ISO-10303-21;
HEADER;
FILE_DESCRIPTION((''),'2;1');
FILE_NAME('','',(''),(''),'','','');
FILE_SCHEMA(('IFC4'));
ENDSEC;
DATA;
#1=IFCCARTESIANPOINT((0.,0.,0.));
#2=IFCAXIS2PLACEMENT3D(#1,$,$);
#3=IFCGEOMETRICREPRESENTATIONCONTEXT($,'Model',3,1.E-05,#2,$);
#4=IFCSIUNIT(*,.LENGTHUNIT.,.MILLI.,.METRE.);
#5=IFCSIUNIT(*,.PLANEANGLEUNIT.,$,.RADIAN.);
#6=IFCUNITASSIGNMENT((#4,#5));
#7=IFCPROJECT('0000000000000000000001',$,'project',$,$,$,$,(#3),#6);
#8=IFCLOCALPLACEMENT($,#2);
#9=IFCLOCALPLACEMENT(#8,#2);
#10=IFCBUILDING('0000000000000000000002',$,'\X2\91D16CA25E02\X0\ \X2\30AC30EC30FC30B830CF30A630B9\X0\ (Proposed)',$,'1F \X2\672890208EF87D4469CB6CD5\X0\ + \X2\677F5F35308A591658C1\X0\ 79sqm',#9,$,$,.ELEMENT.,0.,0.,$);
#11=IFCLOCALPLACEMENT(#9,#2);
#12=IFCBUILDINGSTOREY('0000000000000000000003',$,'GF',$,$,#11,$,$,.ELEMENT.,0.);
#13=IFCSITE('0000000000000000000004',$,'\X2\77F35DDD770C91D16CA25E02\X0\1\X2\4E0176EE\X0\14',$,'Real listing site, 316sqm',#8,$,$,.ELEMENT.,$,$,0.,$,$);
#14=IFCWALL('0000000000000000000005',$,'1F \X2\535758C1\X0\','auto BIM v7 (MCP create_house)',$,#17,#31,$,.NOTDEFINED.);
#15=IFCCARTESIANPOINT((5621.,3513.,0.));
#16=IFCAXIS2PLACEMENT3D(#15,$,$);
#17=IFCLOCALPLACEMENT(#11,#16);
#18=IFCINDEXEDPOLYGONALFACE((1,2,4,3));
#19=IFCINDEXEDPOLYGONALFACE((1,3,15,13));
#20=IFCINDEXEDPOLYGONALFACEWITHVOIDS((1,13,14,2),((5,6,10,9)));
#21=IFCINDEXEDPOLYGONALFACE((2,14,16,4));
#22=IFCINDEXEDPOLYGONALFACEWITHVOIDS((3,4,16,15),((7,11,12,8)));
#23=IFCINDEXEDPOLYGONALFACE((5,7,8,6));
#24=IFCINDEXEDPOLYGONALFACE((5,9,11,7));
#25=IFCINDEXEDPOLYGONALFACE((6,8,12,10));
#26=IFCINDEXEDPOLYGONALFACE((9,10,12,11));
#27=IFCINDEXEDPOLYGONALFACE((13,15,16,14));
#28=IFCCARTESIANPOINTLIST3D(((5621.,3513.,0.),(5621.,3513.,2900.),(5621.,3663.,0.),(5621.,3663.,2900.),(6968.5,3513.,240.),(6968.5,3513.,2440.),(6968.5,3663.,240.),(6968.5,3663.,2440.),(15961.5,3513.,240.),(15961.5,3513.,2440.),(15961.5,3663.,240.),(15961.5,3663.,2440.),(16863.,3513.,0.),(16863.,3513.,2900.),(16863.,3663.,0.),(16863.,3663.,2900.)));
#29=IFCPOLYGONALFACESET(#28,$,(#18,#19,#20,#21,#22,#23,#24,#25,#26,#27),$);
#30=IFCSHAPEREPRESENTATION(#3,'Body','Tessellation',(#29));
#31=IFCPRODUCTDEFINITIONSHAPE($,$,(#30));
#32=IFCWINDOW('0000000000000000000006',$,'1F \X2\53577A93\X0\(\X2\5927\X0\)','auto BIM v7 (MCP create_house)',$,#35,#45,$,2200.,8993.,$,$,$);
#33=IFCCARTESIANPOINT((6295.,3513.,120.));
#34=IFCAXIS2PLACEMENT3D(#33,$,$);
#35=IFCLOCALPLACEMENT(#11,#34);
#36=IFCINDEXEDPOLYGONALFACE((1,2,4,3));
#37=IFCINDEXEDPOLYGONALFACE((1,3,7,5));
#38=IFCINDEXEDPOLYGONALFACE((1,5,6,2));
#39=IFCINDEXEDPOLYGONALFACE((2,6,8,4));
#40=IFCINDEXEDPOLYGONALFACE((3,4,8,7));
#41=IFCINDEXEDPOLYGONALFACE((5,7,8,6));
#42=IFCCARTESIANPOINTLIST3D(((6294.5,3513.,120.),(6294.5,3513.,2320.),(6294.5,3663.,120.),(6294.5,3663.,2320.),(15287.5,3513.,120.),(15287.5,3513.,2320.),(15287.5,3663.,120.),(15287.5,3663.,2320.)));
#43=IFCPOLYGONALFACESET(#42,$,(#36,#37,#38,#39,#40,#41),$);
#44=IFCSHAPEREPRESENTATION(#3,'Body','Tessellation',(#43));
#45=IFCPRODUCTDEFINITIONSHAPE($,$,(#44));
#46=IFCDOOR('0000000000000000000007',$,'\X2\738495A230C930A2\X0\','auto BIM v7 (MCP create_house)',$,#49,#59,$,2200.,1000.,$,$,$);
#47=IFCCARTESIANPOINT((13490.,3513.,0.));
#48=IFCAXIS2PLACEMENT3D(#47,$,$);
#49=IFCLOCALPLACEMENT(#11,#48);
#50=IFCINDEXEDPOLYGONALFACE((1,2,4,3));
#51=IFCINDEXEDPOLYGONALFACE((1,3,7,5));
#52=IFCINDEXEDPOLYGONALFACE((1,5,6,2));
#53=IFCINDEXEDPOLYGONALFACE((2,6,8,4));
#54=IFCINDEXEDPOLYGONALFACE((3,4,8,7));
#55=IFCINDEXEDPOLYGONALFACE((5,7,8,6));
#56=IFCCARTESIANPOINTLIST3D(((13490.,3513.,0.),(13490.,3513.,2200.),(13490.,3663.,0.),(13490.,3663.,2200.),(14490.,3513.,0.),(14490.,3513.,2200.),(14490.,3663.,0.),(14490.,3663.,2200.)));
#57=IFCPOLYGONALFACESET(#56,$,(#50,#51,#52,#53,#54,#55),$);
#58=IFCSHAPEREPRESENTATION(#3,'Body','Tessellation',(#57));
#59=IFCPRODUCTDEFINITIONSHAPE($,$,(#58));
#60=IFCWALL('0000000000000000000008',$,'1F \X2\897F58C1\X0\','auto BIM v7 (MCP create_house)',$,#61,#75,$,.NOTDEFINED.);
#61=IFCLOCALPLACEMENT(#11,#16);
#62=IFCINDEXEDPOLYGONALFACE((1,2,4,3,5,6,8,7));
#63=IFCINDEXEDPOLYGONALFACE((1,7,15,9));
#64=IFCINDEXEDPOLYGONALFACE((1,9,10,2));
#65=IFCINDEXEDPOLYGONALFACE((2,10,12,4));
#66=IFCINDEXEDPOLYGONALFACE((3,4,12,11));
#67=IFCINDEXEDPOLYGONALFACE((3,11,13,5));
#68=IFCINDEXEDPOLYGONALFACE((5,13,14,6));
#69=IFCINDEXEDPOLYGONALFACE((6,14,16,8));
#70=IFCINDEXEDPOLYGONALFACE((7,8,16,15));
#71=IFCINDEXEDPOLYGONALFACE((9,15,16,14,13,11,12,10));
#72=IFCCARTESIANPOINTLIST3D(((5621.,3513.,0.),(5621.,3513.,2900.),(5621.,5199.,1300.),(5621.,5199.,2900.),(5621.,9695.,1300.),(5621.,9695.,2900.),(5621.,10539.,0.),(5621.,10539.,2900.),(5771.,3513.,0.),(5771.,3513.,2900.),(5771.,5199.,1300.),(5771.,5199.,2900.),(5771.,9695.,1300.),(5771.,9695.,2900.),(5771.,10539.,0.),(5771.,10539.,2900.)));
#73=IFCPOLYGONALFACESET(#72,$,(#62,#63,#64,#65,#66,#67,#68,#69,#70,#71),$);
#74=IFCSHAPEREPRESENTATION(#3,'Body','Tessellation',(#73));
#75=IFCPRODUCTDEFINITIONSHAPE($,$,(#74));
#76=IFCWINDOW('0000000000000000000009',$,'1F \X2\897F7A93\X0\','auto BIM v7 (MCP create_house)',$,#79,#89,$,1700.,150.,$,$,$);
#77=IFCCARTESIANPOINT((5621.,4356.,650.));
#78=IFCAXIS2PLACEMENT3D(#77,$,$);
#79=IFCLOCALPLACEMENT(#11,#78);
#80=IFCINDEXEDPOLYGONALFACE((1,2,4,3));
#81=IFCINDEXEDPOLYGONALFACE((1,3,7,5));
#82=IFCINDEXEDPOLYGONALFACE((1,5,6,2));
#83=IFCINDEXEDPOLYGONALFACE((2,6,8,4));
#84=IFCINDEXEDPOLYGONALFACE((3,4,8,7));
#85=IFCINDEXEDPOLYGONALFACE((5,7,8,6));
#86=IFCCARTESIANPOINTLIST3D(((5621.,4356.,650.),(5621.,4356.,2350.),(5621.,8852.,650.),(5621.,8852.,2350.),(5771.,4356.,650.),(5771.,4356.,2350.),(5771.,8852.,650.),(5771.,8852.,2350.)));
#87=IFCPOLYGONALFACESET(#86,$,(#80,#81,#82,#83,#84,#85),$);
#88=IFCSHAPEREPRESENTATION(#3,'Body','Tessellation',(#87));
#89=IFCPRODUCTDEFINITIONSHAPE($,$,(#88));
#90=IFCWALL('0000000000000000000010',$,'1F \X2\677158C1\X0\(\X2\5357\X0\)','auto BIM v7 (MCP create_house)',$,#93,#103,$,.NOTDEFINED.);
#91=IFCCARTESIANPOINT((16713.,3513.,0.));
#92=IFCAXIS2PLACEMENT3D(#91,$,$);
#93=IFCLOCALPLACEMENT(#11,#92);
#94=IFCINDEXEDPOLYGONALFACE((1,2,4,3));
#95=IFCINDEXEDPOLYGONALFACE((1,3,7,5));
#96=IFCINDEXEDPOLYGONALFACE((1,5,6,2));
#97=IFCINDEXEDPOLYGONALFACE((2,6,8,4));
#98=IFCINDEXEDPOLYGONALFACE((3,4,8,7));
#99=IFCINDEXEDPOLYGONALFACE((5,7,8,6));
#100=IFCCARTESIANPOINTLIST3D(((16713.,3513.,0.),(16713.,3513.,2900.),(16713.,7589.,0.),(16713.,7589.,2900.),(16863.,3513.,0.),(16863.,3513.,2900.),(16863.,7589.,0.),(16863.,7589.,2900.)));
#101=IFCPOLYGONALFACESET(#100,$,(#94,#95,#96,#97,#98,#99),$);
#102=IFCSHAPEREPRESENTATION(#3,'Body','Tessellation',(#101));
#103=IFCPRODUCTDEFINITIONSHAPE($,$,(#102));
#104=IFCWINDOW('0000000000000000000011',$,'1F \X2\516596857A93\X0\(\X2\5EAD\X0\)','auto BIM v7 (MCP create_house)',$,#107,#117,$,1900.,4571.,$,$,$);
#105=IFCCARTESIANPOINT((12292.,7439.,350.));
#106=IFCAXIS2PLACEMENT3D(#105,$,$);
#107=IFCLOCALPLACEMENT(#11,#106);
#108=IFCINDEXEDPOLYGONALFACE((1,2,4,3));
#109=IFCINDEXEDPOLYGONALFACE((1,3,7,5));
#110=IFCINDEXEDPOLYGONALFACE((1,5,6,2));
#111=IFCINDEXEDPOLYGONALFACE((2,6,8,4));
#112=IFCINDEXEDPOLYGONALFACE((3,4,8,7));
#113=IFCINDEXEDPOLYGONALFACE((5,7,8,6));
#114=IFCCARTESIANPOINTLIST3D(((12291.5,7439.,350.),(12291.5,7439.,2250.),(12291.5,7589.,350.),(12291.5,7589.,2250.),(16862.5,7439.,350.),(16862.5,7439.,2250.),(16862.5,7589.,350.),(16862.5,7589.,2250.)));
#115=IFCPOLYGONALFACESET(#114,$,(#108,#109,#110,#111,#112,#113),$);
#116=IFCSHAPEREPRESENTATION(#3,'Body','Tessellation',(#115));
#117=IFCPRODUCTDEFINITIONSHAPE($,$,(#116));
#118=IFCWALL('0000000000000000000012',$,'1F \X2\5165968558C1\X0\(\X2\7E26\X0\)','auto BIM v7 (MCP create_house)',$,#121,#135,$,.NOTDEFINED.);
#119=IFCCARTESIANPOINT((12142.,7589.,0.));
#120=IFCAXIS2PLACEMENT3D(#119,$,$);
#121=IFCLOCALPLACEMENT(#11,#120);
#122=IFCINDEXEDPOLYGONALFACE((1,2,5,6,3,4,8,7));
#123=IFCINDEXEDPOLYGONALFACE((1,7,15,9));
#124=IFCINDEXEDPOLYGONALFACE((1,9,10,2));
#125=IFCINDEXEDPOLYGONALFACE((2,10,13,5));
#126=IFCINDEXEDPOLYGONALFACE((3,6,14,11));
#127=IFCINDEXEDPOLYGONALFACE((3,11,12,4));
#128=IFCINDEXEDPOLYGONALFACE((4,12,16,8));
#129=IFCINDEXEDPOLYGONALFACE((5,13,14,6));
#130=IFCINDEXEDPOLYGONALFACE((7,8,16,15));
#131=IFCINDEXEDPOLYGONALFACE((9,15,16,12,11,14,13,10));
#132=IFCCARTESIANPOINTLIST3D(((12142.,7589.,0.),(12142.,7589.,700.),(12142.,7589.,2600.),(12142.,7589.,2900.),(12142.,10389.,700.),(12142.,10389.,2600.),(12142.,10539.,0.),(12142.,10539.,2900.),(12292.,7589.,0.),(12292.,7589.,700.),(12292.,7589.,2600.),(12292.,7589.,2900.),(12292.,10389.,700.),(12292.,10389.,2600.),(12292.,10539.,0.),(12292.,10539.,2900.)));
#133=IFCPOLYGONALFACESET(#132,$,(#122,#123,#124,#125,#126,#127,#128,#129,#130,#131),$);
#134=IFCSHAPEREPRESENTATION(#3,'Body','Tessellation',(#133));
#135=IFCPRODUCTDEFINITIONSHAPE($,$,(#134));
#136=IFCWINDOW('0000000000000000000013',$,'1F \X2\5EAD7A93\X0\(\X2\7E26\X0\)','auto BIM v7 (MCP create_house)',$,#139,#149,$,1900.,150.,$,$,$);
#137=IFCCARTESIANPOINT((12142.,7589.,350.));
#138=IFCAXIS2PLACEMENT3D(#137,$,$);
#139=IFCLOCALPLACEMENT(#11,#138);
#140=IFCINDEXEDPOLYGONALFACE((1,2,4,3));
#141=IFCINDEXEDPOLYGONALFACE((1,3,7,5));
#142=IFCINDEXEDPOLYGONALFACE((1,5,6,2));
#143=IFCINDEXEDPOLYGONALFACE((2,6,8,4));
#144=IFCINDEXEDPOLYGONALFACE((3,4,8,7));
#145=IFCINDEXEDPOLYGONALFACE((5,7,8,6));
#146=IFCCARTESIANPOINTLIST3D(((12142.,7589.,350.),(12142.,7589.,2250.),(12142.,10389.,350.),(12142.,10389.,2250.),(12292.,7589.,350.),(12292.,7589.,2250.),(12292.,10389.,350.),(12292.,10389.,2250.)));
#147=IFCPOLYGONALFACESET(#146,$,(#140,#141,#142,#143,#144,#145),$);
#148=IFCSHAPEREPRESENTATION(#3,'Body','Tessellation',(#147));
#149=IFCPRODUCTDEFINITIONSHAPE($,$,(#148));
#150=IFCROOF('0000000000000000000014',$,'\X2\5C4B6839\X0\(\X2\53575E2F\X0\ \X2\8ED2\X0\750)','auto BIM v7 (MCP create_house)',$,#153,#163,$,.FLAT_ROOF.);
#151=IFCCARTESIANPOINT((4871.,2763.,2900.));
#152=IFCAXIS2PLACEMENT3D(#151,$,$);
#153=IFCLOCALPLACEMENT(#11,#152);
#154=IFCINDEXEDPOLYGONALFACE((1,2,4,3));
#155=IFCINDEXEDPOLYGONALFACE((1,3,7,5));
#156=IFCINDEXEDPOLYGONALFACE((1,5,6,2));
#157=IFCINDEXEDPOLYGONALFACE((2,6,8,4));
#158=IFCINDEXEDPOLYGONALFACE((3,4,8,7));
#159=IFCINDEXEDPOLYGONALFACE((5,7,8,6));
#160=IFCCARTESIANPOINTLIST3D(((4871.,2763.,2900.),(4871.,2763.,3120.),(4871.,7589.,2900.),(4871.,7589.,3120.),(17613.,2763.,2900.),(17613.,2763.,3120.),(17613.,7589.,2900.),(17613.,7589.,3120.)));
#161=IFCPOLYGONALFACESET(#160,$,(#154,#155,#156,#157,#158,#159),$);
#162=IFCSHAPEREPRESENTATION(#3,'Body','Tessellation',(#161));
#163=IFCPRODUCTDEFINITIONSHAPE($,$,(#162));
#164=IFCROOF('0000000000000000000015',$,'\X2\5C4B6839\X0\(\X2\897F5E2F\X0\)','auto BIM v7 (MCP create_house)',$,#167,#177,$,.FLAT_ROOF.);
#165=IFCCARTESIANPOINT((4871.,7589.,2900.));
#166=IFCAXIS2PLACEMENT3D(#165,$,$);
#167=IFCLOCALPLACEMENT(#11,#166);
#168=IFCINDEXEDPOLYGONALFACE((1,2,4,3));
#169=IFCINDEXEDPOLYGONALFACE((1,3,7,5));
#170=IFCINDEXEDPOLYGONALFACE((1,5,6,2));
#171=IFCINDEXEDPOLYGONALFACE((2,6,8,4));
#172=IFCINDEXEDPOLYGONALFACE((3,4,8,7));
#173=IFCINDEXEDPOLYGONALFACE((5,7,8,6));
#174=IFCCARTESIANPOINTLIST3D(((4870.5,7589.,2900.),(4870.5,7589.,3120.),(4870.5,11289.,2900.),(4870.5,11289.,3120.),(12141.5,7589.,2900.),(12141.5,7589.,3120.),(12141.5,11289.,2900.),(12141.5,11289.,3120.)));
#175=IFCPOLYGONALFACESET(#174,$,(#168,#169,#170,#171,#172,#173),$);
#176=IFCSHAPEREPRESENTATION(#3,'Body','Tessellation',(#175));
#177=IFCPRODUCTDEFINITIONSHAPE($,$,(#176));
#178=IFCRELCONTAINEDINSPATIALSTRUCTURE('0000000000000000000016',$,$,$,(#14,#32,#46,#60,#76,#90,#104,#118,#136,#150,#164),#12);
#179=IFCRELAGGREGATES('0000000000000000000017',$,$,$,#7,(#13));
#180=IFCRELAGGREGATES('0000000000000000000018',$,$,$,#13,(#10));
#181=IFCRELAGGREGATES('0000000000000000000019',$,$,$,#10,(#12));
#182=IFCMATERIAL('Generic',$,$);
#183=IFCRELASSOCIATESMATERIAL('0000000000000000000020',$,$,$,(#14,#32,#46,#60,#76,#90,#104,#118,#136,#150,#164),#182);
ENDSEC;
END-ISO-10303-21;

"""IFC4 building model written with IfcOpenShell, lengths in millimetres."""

from ifc_helpers import new_model, si_unit, frame, frame_2d, origin, place, context, project, spatial, rectangle, extrude, material, element, fill, save


model = new_model("IFC4")

# Units and contexts
model_context = context("Model", 3, precision=1e-05, world=origin())
ifc_project = project(units=[si_unit("LENGTHUNIT", "METRE", prefix="MILLI"), si_unit("PLANEANGLEUNIT", "RADIAN")], contexts=[model_context])

# Site, building, storey
site_placement = place(None, origin())
site = spatial("IfcSite", under=ifc_project, at=site_placement, Name="石川県金沢市1丁目14", ObjectType="Real listing site, 316sqm", CompositionType="ELEMENT", RefElevation=0.0)
building_placement = place(site_placement, origin())
building = spatial("IfcBuilding", under=site, at=building_placement, Name="金沢市 ガレージハウス (Proposed)", ObjectType="1F 木造軸組構法 + 板張り外壁 79sqm", CompositionType="ELEMENT", ElevationOfRefHeight=0.0, ElevationOfTerrain=0.0)
storey_placement = place(building_placement, origin())
storey = spatial("IfcBuildingStorey", under=building, at=storey_placement, Name="GF", CompositionType="ELEMENT", Elevation=0.0)

# Shared definitions
ifc_material = material(Name="Generic")

# Wall, openings, window, door
wall_1_placement = place(storey_placement, frame((5621.0, 3513.0, 0.0)))
wall_1 = element("IfcWall", 1, at=wall_1_placement, inside=storey, material=ifc_material, Name="1F 南壁", Description="auto BIM v7 (MCP create_house)", PredefinedType="NOTDEFINED", context=model_context, shape_type="SweptSolid", body=[
    extrude(rectangle(XDim=11242.0, YDim=150.0, at=frame_2d((5621.0, 75.0))), frame((5621.0, 3513.0, 0.0)), (0.0, 0.0, 1.0), 2900.0),
])
opening_1_placement = place(storey_placement, frame((6295.0, 3513.0, 120.0)))
opening_1 = element("IfcOpeningElement", 2, at=opening_1_placement, cuts=wall_1, PredefinedType="NOTDEFINED", context=model_context, shape_type="SweptSolid", body=[
    extrude(rectangle(XDim=8993.0, YDim=150.0, at=frame_2d((4496.0, 75.0))), frame((6295.0, 3513.0, 120.0)), (0.0, 0.0, 1.0), 2200.0),
])
opening_2_placement = place(storey_placement, frame((13490.0, 3513.0, 0.0)))
opening_2 = element("IfcOpeningElement", 3, at=opening_2_placement, cuts=wall_1, PredefinedType="NOTDEFINED", context=model_context, shape_type="SweptSolid", body=[
    extrude(rectangle(XDim=1000.0, YDim=150.0, at=frame_2d((500.0, 75.0))), frame((13490.0, 3513.0, 0.0)), (0.0, 0.0, 1.0), 2200.0),
])
window_1_placement = place(storey_placement, frame((6295.0, 3513.0, 120.0)))
window_1 = element("IfcWindow", 4, at=window_1_placement, inside=storey, material=ifc_material, Name="1F 南窓(大)", Description="auto BIM v7 (MCP create_house)", OverallHeight=2200.0, OverallWidth=8993.0, context=model_context, shape_type="SweptSolid", body=[
    extrude(rectangle(XDim=8993.0, YDim=150.0, at=frame_2d((4496.0, 75.0))), frame((6295.0, 3513.0, 120.0)), (0.0, 0.0, 1.0), 2200.0),
])
fill(opening_1, window_1)
door_placement = place(storey_placement, frame((13490.0, 3513.0, 0.0)))
door = element("IfcDoor", 5, at=door_placement, inside=storey, material=ifc_material, Name="玄関ドア", Description="auto BIM v7 (MCP create_house)", OverallHeight=2200.0, OverallWidth=1000.0, context=model_context, shape_type="SweptSolid", body=[
    extrude(rectangle(XDim=1000.0, YDim=150.0, at=frame_2d((500.0, 75.0))), frame((13490.0, 3513.0, 0.0)), (0.0, 0.0, 1.0), 2200.0),
])
fill(opening_2, door)

# Wall, opening, window
wall_2_placement = place(storey_placement, frame((5621.0, 3513.0, 0.0)))
wall_2 = element("IfcWall", 6, at=wall_2_placement, inside=storey, material=ifc_material, Name="1F 西壁", Description="auto BIM v7 (MCP create_house)", PredefinedType="NOTDEFINED", context=model_context, shape_type="SweptSolid", body=[
    extrude(rectangle(XDim=150.0, YDim=7026.0, at=frame_2d((75.0, 3513.0))), frame((5621.0, 3513.0, 0.0)), (0.0, 0.0, 1.0), 2900.0),
])
opening_3_placement = place(storey_placement, frame((5621.0, 4356.0, 650.0)))
opening_3 = element("IfcOpeningElement", 7, at=opening_3_placement, cuts=wall_2, PredefinedType="NOTDEFINED", context=model_context, shape_type="SweptSolid", body=[
    extrude(rectangle(XDim=150.0, YDim=4496.0, at=frame_2d((75.0, 2248.0))), frame((5621.0, 4356.0, 650.0)), (0.0, 0.0, 1.0), 1700.0),
])
window_2_placement = place(storey_placement, frame((5621.0, 4356.0, 650.0)))
window_2 = element("IfcWindow", 8, at=window_2_placement, inside=storey, material=ifc_material, Name="1F 西窓", Description="auto BIM v7 (MCP create_house)", OverallHeight=1700.0, OverallWidth=150.0, context=model_context, shape_type="SweptSolid", body=[
    extrude(rectangle(XDim=150.0, YDim=4496.0, at=frame_2d((75.0, 2248.0))), frame((5621.0, 4356.0, 650.0)), (0.0, 0.0, 1.0), 1700.0),
])
fill(opening_3, window_2)

# Wall, opening, window
wall_3_placement = place(storey_placement, frame((16713.0, 3513.0, 0.0)))
wall_3 = element("IfcWall", 9, at=wall_3_placement, inside=storey, material=ifc_material, Name="1F 東壁(南)", Description="auto BIM v7 (MCP create_house)", PredefinedType="NOTDEFINED", context=model_context, shape_type="SweptSolid", body=[
    extrude(rectangle(XDim=150.0, YDim=4076.0, at=frame_2d((75.0, 2038.0))), frame((16713.0, 3513.0, 0.0)), (0.0, 0.0, 1.0), 2900.0),
])
opening_4_placement = place(storey_placement, frame((12292.0, 7439.0, 350.0)))
opening_4 = element("IfcOpeningElement", 10, at=opening_4_placement, cuts=wall_3, PredefinedType="NOTDEFINED", context=model_context, shape_type="SweptSolid", body=[
    extrude(rectangle(XDim=4571.0, YDim=150.0, at=frame_2d((2285.0, 75.0))), frame((12292.0, 7439.0, 350.0)), (0.0, 0.0, 1.0), 1900.0),
])
window_3_placement = place(storey_placement, frame((12292.0, 7439.0, 350.0)))
window_3 = element("IfcWindow", 11, at=window_3_placement, inside=storey, material=ifc_material, Name="1F 入隅窓(庭)", Description="auto BIM v7 (MCP create_house)", OverallHeight=1900.0, OverallWidth=4571.0, context=model_context, shape_type="SweptSolid", body=[
    extrude(rectangle(XDim=4571.0, YDim=150.0, at=frame_2d((2285.0, 75.0))), frame((12292.0, 7439.0, 350.0)), (0.0, 0.0, 1.0), 1900.0),
])
fill(opening_4, window_3)

# Wall, opening, window
wall_4_placement = place(storey_placement, frame((12142.0, 7589.0, 0.0)))
wall_4 = element("IfcWall", 12, at=wall_4_placement, inside=storey, material=ifc_material, Name="1F 入隅壁(縦)", Description="auto BIM v7 (MCP create_house)", PredefinedType="NOTDEFINED", context=model_context, shape_type="SweptSolid", body=[
    extrude(rectangle(XDim=150.0, YDim=2950.0, at=frame_2d((75.0, 1475.0))), frame((12142.0, 7589.0, 0.0)), (0.0, 0.0, 1.0), 2900.0),
])
opening_5_placement = place(storey_placement, frame((12142.0, 7589.0, 350.0)))
opening_5 = element("IfcOpeningElement", 13, at=opening_5_placement, cuts=wall_4, PredefinedType="NOTDEFINED", context=model_context, shape_type="SweptSolid", body=[
    extrude(rectangle(XDim=150.0, YDim=2800.0, at=frame_2d((75.0, 1400.0))), frame((12142.0, 7589.0, 350.0)), (0.0, 0.0, 1.0), 1900.0),
])
window_4_placement = place(storey_placement, frame((12142.0, 7589.0, 350.0)))
window_4 = element("IfcWindow", 14, at=window_4_placement, inside=storey, material=ifc_material, Name="1F 庭窓(縦)", Description="auto BIM v7 (MCP create_house)", OverallHeight=1900.0, OverallWidth=150.0, context=model_context, shape_type="SweptSolid", body=[
    extrude(rectangle(XDim=150.0, YDim=2800.0, at=frame_2d((75.0, 1400.0))), frame((12142.0, 7589.0, 350.0)), (0.0, 0.0, 1.0), 1900.0),
])
fill(opening_5, window_4)

# Roofs
roof_1_placement = place(storey_placement, frame((4871.0, 2763.0, 2900.0)))
element("IfcRoof", 15, at=roof_1_placement, inside=storey, material=ifc_material, Name="屋根(南帯 軒750)", Description="auto BIM v7 (MCP create_house)", PredefinedType="FLAT_ROOF", context=model_context, shape_type="SweptSolid", body=[
    extrude(rectangle(XDim=12742.0, YDim=4826.0, at=frame_2d((6371.0, 2413.0))), frame((4871.0, 2763.0, 2900.0)), (0.0, 0.0, 1.0), 220.0),
])
roof_2_placement = place(storey_placement, frame((4871.0, 7589.0, 2900.0)))
element("IfcRoof", 16, at=roof_2_placement, inside=storey, material=ifc_material, Name="屋根(西帯)", Description="auto BIM v7 (MCP create_house)", PredefinedType="FLAT_ROOF", context=model_context, shape_type="SweptSolid", body=[
    extrude(rectangle(XDim=7271.0, YDim=3700.0, at=frame_2d((3635.0, 1850.0))), frame((4871.0, 7589.0, 2900.0)), (0.0, 0.0, 1.0), 220.0),
])

save(model, "model.ifc")
